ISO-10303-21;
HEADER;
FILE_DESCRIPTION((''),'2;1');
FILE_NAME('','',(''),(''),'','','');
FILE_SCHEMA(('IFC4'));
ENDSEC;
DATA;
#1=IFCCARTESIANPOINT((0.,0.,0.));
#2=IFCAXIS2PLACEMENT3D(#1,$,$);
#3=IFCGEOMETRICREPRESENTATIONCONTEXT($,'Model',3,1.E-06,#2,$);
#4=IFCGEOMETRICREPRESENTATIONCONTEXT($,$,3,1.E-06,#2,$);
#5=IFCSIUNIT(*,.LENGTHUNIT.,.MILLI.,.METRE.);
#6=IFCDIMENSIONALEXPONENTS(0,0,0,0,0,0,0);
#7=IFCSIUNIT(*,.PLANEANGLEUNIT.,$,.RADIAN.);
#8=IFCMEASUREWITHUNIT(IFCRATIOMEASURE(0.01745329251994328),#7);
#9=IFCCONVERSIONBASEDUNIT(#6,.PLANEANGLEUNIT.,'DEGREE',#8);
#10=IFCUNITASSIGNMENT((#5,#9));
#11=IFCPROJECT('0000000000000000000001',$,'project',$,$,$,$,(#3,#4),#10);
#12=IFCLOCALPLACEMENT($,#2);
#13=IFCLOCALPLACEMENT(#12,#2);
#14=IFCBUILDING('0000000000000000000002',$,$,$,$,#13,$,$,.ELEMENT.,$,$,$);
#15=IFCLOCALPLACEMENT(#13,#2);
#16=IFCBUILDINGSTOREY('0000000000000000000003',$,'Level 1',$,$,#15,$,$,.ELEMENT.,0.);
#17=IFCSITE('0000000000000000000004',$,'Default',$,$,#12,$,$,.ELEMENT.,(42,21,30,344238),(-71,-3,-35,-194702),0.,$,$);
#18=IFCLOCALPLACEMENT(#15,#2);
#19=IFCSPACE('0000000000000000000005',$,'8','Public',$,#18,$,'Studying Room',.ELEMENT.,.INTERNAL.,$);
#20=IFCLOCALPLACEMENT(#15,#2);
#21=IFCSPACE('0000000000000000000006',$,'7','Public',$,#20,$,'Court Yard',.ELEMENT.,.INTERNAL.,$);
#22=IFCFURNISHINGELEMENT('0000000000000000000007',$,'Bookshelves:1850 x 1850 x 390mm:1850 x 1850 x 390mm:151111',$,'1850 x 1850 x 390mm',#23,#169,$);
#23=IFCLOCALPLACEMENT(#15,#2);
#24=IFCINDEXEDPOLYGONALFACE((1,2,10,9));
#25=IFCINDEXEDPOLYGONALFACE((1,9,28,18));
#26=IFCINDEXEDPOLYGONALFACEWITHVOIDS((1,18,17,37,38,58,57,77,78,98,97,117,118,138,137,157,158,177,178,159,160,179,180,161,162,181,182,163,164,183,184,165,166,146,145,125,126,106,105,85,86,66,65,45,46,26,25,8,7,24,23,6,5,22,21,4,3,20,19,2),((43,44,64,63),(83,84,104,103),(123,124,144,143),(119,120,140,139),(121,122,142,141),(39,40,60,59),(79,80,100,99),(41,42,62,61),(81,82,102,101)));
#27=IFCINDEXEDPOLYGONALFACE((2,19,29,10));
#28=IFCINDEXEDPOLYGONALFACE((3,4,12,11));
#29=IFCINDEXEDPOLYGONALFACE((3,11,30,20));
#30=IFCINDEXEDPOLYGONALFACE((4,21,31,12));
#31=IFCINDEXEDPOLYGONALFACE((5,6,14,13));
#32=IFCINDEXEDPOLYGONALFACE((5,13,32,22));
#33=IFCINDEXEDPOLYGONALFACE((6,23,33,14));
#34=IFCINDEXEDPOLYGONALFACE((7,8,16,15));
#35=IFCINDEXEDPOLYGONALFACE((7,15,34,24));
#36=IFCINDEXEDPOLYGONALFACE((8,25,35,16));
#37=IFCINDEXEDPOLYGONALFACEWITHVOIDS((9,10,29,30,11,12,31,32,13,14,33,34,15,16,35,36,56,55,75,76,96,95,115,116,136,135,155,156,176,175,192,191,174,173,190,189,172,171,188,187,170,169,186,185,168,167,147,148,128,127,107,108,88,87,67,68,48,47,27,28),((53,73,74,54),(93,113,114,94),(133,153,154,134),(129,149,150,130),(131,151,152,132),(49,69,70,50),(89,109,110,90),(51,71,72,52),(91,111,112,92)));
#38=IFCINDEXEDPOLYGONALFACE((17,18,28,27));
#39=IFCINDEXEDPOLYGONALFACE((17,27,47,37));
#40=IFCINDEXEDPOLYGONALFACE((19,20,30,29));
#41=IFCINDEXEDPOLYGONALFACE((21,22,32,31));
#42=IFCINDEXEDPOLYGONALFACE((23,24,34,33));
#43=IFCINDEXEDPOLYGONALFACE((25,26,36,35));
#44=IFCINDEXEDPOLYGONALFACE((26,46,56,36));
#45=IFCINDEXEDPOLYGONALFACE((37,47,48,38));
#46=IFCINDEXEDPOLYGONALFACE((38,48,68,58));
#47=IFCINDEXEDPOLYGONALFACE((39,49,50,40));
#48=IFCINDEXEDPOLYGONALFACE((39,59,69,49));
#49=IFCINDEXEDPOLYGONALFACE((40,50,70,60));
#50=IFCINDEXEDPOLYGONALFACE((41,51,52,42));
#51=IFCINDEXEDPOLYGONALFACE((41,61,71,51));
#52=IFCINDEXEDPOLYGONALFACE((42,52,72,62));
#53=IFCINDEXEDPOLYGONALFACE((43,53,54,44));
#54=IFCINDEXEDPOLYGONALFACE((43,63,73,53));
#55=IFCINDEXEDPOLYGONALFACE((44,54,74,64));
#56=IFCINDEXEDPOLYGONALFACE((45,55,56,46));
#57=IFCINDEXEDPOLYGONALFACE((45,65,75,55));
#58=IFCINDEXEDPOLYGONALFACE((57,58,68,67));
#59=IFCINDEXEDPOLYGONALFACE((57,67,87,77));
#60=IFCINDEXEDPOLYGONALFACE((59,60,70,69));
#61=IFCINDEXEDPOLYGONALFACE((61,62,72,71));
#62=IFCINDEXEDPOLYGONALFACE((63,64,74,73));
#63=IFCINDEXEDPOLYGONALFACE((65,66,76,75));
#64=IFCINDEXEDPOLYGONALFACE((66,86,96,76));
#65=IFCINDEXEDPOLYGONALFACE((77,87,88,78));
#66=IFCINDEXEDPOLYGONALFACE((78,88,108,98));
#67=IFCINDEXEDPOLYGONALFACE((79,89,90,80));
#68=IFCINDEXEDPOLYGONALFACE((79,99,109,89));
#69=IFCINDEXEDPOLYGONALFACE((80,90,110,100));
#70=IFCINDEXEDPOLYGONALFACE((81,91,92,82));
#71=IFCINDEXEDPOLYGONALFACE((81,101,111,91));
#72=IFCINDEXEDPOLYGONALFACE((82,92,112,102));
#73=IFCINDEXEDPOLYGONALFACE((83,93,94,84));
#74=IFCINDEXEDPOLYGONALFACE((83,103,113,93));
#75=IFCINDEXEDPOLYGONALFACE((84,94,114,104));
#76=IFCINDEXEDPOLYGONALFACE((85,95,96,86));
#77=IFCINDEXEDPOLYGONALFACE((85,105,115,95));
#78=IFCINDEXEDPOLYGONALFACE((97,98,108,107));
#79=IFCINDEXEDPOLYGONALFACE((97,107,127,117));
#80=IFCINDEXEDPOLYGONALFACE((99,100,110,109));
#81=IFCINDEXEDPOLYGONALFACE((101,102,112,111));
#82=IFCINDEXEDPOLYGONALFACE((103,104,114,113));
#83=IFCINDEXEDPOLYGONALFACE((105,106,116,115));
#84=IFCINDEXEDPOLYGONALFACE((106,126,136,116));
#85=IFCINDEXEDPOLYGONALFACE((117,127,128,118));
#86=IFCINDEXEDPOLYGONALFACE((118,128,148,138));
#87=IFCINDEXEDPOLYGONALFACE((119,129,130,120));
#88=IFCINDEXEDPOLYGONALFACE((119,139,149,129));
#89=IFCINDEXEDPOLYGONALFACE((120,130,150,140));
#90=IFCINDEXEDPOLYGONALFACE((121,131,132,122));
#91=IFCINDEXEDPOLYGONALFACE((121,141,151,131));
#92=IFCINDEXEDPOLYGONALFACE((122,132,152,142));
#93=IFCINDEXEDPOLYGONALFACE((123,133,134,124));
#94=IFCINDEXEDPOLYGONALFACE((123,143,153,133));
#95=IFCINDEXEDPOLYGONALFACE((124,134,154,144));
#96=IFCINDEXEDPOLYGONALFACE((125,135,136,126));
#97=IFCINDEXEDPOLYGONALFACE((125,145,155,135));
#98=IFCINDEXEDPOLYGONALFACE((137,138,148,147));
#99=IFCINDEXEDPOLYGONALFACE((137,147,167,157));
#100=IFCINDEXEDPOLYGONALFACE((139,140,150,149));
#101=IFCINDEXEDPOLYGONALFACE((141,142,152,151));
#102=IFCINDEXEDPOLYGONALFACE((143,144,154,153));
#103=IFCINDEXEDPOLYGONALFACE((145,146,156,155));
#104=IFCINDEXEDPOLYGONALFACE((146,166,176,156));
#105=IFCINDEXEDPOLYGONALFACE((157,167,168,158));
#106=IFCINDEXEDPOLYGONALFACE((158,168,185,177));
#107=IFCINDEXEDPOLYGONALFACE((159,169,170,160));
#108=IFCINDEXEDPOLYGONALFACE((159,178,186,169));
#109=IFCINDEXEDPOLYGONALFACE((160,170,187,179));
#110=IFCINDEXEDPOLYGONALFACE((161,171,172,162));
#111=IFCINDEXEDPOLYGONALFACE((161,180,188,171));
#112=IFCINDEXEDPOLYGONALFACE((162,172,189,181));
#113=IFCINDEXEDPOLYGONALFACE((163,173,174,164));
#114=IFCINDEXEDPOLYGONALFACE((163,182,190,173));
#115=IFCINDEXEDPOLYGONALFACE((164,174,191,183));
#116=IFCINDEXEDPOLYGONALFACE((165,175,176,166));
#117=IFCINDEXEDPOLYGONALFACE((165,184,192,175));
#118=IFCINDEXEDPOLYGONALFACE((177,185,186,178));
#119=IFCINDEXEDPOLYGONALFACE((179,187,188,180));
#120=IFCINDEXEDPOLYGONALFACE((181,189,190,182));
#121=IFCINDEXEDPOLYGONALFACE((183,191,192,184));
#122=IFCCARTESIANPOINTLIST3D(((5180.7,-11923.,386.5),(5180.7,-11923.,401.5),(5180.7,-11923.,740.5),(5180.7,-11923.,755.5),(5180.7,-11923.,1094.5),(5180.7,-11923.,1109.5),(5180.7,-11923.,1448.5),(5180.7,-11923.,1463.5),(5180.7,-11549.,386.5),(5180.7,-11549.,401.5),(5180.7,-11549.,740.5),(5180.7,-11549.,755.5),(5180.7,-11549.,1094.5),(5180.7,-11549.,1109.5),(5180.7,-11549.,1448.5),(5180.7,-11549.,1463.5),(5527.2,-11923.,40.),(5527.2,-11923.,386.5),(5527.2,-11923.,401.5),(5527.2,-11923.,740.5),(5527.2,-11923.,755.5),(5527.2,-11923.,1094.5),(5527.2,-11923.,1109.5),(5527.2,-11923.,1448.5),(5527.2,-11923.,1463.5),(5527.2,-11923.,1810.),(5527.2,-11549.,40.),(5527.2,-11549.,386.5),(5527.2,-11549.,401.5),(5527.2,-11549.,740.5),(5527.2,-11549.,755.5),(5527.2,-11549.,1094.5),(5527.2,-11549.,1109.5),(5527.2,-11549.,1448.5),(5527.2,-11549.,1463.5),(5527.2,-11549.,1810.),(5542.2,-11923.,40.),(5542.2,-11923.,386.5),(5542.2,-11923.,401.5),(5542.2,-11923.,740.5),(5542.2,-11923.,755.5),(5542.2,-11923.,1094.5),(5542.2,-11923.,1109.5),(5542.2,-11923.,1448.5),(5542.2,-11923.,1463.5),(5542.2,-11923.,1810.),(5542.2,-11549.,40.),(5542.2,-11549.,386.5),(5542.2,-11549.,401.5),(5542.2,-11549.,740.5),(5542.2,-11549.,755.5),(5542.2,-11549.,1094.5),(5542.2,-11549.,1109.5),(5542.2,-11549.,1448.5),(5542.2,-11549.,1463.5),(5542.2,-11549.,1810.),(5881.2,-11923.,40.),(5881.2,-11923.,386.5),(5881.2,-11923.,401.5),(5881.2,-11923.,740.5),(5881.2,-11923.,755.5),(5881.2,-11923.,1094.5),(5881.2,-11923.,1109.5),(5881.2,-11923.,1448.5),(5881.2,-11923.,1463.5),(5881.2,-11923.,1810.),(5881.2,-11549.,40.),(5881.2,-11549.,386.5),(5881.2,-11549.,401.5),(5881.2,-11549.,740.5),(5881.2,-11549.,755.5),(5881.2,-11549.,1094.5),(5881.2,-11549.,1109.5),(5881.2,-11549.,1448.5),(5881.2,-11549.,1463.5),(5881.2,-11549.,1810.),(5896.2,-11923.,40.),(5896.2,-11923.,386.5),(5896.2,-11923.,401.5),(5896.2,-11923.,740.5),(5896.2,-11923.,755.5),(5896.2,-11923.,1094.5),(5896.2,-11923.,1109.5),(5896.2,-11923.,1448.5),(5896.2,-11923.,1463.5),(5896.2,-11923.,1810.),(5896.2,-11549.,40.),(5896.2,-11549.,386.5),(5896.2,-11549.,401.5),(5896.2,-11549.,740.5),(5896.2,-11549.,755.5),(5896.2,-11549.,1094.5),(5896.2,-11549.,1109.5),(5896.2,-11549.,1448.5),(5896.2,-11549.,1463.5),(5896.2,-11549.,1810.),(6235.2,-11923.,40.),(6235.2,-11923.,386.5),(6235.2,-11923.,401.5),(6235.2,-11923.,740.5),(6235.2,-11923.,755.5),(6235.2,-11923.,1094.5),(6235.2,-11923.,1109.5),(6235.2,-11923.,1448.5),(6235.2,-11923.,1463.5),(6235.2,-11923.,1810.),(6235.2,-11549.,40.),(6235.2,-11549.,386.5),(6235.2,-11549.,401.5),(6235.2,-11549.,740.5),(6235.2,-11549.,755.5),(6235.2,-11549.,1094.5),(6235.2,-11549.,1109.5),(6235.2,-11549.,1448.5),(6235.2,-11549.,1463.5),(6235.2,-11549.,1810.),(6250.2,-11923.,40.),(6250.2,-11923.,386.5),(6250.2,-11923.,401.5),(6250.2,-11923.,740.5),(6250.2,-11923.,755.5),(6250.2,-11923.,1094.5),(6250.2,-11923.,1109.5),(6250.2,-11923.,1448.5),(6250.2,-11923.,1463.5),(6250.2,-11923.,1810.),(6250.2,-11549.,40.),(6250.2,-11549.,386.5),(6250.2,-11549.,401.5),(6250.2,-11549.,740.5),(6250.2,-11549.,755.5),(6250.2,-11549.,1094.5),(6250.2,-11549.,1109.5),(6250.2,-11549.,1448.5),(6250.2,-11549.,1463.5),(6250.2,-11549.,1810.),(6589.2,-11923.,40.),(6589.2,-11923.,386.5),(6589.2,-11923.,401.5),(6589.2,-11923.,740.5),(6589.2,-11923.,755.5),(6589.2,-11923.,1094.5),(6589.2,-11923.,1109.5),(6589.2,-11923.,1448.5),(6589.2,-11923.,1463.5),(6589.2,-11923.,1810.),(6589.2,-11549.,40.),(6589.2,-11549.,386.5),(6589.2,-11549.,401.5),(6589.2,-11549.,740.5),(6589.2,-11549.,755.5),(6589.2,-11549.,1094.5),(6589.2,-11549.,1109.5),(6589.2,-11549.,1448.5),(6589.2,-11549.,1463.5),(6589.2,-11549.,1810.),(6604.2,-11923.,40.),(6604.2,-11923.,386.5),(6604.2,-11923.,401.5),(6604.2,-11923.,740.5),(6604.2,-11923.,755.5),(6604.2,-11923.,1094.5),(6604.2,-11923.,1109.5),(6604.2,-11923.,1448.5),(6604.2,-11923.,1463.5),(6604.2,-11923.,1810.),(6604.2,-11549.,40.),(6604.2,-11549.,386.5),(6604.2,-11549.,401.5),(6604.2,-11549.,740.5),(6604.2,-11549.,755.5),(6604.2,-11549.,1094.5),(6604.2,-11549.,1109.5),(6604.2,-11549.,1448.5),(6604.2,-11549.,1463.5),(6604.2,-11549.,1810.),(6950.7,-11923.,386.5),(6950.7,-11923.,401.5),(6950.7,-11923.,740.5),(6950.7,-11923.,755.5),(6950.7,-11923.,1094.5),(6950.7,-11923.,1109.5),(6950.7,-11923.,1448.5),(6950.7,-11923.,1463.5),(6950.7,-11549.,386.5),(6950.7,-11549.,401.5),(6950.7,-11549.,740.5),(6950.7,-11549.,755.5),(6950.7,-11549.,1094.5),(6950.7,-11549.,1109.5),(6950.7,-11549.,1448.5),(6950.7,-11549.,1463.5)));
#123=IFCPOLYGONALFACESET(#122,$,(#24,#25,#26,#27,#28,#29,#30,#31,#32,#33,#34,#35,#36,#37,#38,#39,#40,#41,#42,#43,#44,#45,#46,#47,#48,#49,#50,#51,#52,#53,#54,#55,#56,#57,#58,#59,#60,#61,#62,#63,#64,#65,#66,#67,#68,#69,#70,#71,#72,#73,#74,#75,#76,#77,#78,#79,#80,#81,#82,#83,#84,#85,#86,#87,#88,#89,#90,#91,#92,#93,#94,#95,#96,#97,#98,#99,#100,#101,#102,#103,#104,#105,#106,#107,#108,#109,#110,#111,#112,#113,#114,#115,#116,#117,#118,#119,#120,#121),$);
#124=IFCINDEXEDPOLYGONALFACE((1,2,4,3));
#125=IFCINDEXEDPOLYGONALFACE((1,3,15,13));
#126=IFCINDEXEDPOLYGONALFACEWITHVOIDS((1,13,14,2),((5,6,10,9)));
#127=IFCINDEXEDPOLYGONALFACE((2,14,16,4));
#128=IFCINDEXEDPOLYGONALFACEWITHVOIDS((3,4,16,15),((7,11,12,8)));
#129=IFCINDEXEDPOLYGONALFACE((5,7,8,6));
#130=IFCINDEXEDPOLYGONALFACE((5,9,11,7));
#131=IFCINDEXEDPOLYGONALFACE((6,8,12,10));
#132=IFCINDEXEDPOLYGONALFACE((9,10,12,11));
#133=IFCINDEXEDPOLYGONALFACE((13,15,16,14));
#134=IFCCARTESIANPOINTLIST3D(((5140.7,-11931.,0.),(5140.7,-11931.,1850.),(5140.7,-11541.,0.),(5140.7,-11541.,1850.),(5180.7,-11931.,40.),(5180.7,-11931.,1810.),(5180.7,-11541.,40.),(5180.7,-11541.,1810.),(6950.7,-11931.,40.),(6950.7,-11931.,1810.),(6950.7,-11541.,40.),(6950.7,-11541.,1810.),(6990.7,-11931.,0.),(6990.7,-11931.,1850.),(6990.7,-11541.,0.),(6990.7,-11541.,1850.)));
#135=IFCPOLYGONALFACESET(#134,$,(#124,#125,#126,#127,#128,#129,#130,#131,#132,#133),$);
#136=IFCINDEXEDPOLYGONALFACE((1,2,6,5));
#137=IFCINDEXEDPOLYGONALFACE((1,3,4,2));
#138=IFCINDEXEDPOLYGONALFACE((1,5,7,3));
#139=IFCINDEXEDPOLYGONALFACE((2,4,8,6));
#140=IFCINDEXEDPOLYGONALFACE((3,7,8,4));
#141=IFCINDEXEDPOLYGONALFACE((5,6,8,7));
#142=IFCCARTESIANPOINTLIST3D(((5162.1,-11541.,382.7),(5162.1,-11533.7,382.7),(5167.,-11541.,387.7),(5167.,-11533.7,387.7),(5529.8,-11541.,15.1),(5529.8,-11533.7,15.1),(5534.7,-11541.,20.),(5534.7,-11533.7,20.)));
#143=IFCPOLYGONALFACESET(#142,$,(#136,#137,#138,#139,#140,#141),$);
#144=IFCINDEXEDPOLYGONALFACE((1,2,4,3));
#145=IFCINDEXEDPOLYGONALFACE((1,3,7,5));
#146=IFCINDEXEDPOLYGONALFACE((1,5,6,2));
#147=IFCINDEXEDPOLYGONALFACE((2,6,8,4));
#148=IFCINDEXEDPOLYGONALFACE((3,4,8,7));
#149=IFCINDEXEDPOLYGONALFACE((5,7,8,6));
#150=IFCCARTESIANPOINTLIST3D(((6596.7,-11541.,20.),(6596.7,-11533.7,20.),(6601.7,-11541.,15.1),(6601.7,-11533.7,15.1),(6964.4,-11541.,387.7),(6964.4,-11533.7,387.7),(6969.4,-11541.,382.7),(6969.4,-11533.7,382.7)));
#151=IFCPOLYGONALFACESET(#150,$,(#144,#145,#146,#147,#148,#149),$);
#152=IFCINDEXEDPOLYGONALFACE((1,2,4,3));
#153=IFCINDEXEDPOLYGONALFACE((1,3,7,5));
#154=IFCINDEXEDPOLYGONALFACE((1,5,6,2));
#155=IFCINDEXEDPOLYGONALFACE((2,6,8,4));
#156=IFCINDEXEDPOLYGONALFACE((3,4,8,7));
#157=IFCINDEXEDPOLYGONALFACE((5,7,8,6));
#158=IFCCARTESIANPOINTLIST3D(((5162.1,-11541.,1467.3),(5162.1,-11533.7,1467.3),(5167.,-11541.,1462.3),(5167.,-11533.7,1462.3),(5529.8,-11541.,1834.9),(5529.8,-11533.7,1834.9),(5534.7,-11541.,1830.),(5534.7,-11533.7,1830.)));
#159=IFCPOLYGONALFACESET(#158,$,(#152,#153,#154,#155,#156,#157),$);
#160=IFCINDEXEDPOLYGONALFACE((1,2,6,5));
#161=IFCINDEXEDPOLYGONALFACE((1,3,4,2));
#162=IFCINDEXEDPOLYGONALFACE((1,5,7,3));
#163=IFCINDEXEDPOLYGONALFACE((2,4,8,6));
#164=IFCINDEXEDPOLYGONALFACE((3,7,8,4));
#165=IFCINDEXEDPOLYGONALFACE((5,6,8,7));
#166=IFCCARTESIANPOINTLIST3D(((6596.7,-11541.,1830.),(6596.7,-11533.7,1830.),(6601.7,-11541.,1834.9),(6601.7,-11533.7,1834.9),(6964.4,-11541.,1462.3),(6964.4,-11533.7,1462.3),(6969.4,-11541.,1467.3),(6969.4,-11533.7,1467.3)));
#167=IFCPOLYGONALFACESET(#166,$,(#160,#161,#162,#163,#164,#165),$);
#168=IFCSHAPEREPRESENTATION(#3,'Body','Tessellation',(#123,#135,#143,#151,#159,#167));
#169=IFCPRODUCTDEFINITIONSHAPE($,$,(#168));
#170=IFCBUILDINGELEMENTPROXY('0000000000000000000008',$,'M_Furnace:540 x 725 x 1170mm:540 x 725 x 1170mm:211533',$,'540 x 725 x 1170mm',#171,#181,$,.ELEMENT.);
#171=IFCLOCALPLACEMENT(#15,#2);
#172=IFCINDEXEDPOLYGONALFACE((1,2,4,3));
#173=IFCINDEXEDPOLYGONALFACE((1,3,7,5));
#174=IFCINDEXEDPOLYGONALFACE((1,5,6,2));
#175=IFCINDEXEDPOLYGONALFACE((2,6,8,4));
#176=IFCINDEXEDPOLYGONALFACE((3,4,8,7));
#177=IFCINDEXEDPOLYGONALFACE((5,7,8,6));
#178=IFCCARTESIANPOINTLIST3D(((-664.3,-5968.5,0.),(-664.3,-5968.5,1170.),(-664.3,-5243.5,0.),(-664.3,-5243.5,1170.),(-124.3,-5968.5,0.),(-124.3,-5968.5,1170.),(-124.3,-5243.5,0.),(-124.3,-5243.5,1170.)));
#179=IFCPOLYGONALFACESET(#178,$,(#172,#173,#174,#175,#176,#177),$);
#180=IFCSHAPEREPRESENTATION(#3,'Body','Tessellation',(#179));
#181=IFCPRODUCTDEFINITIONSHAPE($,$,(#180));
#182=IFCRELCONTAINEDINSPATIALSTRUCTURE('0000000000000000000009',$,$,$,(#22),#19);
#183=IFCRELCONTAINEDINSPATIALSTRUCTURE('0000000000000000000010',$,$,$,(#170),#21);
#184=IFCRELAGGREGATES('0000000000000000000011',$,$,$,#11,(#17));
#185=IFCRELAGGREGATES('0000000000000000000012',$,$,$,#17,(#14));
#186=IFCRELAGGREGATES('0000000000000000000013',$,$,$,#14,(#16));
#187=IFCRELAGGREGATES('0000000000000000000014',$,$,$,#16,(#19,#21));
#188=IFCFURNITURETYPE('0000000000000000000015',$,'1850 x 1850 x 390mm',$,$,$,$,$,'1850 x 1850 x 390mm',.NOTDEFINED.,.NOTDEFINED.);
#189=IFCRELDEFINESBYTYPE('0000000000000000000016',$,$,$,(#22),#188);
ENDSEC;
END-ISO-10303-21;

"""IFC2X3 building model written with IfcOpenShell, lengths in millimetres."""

from ifc_helpers import new_model, entity, si_unit, converted_unit, frame, frame_2d, origin, origin_2d_with_axis, place, context, project, spatial, polyline, rectangle, outline, extrude, source, transform, mapped, type_object, type_shapes, element, save


model = new_model("IFC2X3")

# Units and contexts
model_context = context("Model", 3, precision=1e-06, world=origin())
context_of_model = context(None, 3, precision=1e-06, world=origin())
ifc_project = project(units=[si_unit("LENGTHUNIT", "METRE", prefix="MILLI"), converted_unit("PLANEANGLEUNIT", "DEGREE", entity("IfcRatioMeasure", 0.01745329251994328), si_unit("PLANEANGLEUNIT", "RADIAN"), dimensions=[0, 0, 0, 0, 0, 0, 0])], contexts=[model_context, context_of_model])

# Site, building, storey
site_placement = place(None, origin())
site = spatial("IfcSite", under=ifc_project, at=site_placement, Name="Default", CompositionType="ELEMENT", RefLatitude=(42, 21, 30, 344238), RefLongitude=(-71, -3, -35, -194702), RefElevation=0.0)
building_placement = place(site_placement, origin())
building = spatial("IfcBuilding", under=site, at=building_placement, CompositionType="ELEMENT")
storey_placement = place(building_placement, origin())
storey = spatial("IfcBuildingStorey", under=building, at=storey_placement, Name="Level 1", CompositionType="ELEMENT", Elevation=0.0)

# Shared definitions
space_1_placement = place(storey_placement, origin())
space_1 = spatial("IfcSpace", under=storey, at=space_1_placement, Name="8", Description="Public", LongName="Studying Room", CompositionType="ELEMENT", InteriorOrExteriorSpace="INTERNAL")

# Furnishing element
furniture_type = type_object("IfcFurnitureType", Name="1850 x 1850 x 390mm", ElementType="1850 x 1850 x 390mm", AssemblyPlace="NOTDEFINED")
shared_shape_1 = source(origin(), model_context, "Body", "SweptSolid", [
    extrude(outline(polyline([(538.5, -538.5), (885.0, -538.5), (885.0, -523.5), (538.5, -523.5), (538.5, -184.5), (885.0, -184.5), (885.0, -169.5), (538.5, -169.5), (538.5, 169.5), (885.0, 169.5), (885.0, 184.5), (538.5, 184.5), (538.5, 523.5), (885.0, 523.5), (885.0, 538.5), (538.5, 538.5), (538.5, 885.0), (523.5, 885.0), (523.5, 538.5), (184.5, 538.5), (184.5, 885.0), (169.5, 885.0), (169.5, 538.5), (-169.5, 538.5), (-169.5, 885.0), (-184.5, 885.0), (-184.5, 538.5), (-523.5, 538.5), (-523.5, 885.0), (-538.5, 885.0), (-538.5, 538.5), (-885.0, 538.5), (-885.0, 523.5), (-538.5, 523.5), (-538.5, 184.5), (-885.0, 184.5), (-885.0, 169.5), (-538.5, 169.5), (-538.5, -169.5), (-885.0, -169.5), (-885.0, -184.5), (-538.5, -184.5), (-538.5, -523.5), (-885.0, -523.5), (-885.0, -538.5), (-538.5, -538.5), (-538.5, -885.0), (-523.5, -885.0), (-523.5, -538.5), (-184.5, -538.5), (-184.5, -885.0), (-169.5, -885.0), (-169.5, -538.5), (169.5, -538.5), (169.5, -885.0), (184.5, -885.0), (184.5, -538.5), (523.5, -538.5), (523.5, -885.0), (538.5, -885.0), (538.5, -538.5)]), holes=[polyline([(523.5, -184.5), (523.5, -523.5), (184.5, -523.5), (184.5, -184.5), (523.5, -184.5)]), polyline([(184.5, -169.5), (184.5, 169.5), (523.5, 169.5), (523.5, -169.5), (184.5, -169.5)]), polyline([(184.5, 184.5), (184.5, 523.5), (523.5, 523.5), (523.5, 184.5), (184.5, 184.5)]), polyline([(-169.5, 523.5), (169.5, 523.5), (169.5, 184.5), (-169.5, 184.5), (-169.5, 523.5)]), polyline([(-169.5, 169.5), (169.5, 169.5), (169.5, -169.5), (-169.5, -169.5), (-169.5, 169.5)]), polyline([(-169.5, -184.5), (169.5, -184.5), (169.5, -523.5), (-169.5, -523.5), (-169.5, -184.5)]), polyline([(-523.5, -523.5), (-523.5, -184.5), (-184.5, -184.5), (-184.5, -523.5), (-523.5, -523.5)]), polyline([(-523.5, -169.5), (-523.5, 169.5), (-184.5, 169.5), (-184.5, -169.5), (-523.5, -169.5)]), polyline([(-523.5, 184.5), (-523.5, 523.5), (-184.5, 523.5), (-184.5, 184.5), (-523.5, 184.5)])]), frame((247.1, -257.1, 925.0), z_axis=(0.0, 1.0, 0.0), x_axis=(0.0, 0.0, 1.0)), (0.0, 0.0, 1.0), 374.0),
    extrude(outline(polyline([(-925.0, -925.0), (925.0, -925.0), (925.0, 925.0), (-925.0, 925.0), (-925.0, -925.0)]), holes=[polyline([(-885.0, -885.0), (-885.0, 885.0), (885.0, 885.0), (885.0, -885.0), (-885.0, -885.0)])]), frame((247.1, -265.1, 925.0), z_axis=(0.0, 1.0, 0.0), x_axis=(0.0, 0.0, -1.0)), (0.0, 0.0, 1.0), 390.0),
    extrude(rectangle(XDim=7.0, YDim=7.3, at=frame_2d((0.0, 0.0), x_axis=(0.0, 1.0))), frame((-286.4, 128.6, 17.5), z_axis=(-0.707107, 0.0, 0.707107), x_axis=(0.0, 1.0, 0.0)), (0.0, 0.0, 1.0), 520.0),
    extrude(rectangle(XDim=7.0, YDim=7.3, at=frame_2d((0.0, 0.0), x_axis=(0.0, 1.0))), frame((780.5, 128.6, 17.5), z_axis=(0.707107, 0.0, 0.707107), x_axis=(0.0, 1.0, 0.0)), (0.0, 0.0, 1.0), 520.0),
    extrude(rectangle(XDim=7.0, YDim=7.3, at=frame_2d((0.0, 0.0), x_axis=(0.0, 1.0))), frame((-654.1, 128.6, 1464.8), z_axis=(0.707107, 0.0, 0.707107), x_axis=(0.0, 1.0, 0.0)), (0.0, 0.0, 1.0), 520.0),
    extrude(rectangle(XDim=7.0, YDim=7.3, at=frame_2d((0.0, 0.0), x_axis=(0.0, 1.0))), frame((1148.2, 128.6, 1464.8), z_axis=(-0.707107, 0.0, 0.707107), x_axis=(0.0, 1.0, 0.0)), (0.0, 0.0, 1.0), 520.0),
])
type_shapes(furniture_type, [shared_shape_1])
furnishing_placement = place(space_1_placement, frame((5818.7, -11665.9, 0.0)))
element("IfcFurnishingElement", 1, at=furnishing_placement, inside=space_1, type_object=furniture_type, Name="Bookshelves:1850 x 1850 x 390mm:1850 x 1850 x 390mm:151111", ObjectType="1850 x 1850 x 390mm", context=model_context, shape_type="MappedRepresentation", body=[
    mapped(shared_shape_1, transform((0.0, 0.0, 0.0), scale=1.0)),
])

# Shared definitions
space_2_placement = place(storey_placement, origin())
space_2 = spatial("IfcSpace", under=storey, at=space_2_placement, Name="7", Description="Public", LongName="Court Yard", CompositionType="ELEMENT", InteriorOrExteriorSpace="INTERNAL")

# Building element proxy
shared_shape_2 = source(origin(), model_context, "Body", "SweptSolid", [
    extrude(rectangle(XDim=725.0, YDim=540.0, at=origin_2d_with_axis()), frame((0.0, 0.0, 0.0), z_axis=(0.0, 0.0, 1.0), x_axis=(0.0, 1.0, 0.0)), (0.0, 0.0, 1.0), 1170.0),
])
proxy_placement = place(space_2_placement, frame((-394.3, -5606.0, 0.0)))
element("IfcBuildingElementProxy", 2, at=proxy_placement, inside=space_2, Name="M_Furnace:540 x 725 x 1170mm:540 x 725 x 1170mm:211533", ObjectType="540 x 725 x 1170mm", CompositionType="ELEMENT", context=model_context, shape_type="MappedRepresentation", body=[
    mapped(shared_shape_2, transform((0.0, 0.0, 0.0), scale=1.0)),
])

save(model, "model.ifc")
